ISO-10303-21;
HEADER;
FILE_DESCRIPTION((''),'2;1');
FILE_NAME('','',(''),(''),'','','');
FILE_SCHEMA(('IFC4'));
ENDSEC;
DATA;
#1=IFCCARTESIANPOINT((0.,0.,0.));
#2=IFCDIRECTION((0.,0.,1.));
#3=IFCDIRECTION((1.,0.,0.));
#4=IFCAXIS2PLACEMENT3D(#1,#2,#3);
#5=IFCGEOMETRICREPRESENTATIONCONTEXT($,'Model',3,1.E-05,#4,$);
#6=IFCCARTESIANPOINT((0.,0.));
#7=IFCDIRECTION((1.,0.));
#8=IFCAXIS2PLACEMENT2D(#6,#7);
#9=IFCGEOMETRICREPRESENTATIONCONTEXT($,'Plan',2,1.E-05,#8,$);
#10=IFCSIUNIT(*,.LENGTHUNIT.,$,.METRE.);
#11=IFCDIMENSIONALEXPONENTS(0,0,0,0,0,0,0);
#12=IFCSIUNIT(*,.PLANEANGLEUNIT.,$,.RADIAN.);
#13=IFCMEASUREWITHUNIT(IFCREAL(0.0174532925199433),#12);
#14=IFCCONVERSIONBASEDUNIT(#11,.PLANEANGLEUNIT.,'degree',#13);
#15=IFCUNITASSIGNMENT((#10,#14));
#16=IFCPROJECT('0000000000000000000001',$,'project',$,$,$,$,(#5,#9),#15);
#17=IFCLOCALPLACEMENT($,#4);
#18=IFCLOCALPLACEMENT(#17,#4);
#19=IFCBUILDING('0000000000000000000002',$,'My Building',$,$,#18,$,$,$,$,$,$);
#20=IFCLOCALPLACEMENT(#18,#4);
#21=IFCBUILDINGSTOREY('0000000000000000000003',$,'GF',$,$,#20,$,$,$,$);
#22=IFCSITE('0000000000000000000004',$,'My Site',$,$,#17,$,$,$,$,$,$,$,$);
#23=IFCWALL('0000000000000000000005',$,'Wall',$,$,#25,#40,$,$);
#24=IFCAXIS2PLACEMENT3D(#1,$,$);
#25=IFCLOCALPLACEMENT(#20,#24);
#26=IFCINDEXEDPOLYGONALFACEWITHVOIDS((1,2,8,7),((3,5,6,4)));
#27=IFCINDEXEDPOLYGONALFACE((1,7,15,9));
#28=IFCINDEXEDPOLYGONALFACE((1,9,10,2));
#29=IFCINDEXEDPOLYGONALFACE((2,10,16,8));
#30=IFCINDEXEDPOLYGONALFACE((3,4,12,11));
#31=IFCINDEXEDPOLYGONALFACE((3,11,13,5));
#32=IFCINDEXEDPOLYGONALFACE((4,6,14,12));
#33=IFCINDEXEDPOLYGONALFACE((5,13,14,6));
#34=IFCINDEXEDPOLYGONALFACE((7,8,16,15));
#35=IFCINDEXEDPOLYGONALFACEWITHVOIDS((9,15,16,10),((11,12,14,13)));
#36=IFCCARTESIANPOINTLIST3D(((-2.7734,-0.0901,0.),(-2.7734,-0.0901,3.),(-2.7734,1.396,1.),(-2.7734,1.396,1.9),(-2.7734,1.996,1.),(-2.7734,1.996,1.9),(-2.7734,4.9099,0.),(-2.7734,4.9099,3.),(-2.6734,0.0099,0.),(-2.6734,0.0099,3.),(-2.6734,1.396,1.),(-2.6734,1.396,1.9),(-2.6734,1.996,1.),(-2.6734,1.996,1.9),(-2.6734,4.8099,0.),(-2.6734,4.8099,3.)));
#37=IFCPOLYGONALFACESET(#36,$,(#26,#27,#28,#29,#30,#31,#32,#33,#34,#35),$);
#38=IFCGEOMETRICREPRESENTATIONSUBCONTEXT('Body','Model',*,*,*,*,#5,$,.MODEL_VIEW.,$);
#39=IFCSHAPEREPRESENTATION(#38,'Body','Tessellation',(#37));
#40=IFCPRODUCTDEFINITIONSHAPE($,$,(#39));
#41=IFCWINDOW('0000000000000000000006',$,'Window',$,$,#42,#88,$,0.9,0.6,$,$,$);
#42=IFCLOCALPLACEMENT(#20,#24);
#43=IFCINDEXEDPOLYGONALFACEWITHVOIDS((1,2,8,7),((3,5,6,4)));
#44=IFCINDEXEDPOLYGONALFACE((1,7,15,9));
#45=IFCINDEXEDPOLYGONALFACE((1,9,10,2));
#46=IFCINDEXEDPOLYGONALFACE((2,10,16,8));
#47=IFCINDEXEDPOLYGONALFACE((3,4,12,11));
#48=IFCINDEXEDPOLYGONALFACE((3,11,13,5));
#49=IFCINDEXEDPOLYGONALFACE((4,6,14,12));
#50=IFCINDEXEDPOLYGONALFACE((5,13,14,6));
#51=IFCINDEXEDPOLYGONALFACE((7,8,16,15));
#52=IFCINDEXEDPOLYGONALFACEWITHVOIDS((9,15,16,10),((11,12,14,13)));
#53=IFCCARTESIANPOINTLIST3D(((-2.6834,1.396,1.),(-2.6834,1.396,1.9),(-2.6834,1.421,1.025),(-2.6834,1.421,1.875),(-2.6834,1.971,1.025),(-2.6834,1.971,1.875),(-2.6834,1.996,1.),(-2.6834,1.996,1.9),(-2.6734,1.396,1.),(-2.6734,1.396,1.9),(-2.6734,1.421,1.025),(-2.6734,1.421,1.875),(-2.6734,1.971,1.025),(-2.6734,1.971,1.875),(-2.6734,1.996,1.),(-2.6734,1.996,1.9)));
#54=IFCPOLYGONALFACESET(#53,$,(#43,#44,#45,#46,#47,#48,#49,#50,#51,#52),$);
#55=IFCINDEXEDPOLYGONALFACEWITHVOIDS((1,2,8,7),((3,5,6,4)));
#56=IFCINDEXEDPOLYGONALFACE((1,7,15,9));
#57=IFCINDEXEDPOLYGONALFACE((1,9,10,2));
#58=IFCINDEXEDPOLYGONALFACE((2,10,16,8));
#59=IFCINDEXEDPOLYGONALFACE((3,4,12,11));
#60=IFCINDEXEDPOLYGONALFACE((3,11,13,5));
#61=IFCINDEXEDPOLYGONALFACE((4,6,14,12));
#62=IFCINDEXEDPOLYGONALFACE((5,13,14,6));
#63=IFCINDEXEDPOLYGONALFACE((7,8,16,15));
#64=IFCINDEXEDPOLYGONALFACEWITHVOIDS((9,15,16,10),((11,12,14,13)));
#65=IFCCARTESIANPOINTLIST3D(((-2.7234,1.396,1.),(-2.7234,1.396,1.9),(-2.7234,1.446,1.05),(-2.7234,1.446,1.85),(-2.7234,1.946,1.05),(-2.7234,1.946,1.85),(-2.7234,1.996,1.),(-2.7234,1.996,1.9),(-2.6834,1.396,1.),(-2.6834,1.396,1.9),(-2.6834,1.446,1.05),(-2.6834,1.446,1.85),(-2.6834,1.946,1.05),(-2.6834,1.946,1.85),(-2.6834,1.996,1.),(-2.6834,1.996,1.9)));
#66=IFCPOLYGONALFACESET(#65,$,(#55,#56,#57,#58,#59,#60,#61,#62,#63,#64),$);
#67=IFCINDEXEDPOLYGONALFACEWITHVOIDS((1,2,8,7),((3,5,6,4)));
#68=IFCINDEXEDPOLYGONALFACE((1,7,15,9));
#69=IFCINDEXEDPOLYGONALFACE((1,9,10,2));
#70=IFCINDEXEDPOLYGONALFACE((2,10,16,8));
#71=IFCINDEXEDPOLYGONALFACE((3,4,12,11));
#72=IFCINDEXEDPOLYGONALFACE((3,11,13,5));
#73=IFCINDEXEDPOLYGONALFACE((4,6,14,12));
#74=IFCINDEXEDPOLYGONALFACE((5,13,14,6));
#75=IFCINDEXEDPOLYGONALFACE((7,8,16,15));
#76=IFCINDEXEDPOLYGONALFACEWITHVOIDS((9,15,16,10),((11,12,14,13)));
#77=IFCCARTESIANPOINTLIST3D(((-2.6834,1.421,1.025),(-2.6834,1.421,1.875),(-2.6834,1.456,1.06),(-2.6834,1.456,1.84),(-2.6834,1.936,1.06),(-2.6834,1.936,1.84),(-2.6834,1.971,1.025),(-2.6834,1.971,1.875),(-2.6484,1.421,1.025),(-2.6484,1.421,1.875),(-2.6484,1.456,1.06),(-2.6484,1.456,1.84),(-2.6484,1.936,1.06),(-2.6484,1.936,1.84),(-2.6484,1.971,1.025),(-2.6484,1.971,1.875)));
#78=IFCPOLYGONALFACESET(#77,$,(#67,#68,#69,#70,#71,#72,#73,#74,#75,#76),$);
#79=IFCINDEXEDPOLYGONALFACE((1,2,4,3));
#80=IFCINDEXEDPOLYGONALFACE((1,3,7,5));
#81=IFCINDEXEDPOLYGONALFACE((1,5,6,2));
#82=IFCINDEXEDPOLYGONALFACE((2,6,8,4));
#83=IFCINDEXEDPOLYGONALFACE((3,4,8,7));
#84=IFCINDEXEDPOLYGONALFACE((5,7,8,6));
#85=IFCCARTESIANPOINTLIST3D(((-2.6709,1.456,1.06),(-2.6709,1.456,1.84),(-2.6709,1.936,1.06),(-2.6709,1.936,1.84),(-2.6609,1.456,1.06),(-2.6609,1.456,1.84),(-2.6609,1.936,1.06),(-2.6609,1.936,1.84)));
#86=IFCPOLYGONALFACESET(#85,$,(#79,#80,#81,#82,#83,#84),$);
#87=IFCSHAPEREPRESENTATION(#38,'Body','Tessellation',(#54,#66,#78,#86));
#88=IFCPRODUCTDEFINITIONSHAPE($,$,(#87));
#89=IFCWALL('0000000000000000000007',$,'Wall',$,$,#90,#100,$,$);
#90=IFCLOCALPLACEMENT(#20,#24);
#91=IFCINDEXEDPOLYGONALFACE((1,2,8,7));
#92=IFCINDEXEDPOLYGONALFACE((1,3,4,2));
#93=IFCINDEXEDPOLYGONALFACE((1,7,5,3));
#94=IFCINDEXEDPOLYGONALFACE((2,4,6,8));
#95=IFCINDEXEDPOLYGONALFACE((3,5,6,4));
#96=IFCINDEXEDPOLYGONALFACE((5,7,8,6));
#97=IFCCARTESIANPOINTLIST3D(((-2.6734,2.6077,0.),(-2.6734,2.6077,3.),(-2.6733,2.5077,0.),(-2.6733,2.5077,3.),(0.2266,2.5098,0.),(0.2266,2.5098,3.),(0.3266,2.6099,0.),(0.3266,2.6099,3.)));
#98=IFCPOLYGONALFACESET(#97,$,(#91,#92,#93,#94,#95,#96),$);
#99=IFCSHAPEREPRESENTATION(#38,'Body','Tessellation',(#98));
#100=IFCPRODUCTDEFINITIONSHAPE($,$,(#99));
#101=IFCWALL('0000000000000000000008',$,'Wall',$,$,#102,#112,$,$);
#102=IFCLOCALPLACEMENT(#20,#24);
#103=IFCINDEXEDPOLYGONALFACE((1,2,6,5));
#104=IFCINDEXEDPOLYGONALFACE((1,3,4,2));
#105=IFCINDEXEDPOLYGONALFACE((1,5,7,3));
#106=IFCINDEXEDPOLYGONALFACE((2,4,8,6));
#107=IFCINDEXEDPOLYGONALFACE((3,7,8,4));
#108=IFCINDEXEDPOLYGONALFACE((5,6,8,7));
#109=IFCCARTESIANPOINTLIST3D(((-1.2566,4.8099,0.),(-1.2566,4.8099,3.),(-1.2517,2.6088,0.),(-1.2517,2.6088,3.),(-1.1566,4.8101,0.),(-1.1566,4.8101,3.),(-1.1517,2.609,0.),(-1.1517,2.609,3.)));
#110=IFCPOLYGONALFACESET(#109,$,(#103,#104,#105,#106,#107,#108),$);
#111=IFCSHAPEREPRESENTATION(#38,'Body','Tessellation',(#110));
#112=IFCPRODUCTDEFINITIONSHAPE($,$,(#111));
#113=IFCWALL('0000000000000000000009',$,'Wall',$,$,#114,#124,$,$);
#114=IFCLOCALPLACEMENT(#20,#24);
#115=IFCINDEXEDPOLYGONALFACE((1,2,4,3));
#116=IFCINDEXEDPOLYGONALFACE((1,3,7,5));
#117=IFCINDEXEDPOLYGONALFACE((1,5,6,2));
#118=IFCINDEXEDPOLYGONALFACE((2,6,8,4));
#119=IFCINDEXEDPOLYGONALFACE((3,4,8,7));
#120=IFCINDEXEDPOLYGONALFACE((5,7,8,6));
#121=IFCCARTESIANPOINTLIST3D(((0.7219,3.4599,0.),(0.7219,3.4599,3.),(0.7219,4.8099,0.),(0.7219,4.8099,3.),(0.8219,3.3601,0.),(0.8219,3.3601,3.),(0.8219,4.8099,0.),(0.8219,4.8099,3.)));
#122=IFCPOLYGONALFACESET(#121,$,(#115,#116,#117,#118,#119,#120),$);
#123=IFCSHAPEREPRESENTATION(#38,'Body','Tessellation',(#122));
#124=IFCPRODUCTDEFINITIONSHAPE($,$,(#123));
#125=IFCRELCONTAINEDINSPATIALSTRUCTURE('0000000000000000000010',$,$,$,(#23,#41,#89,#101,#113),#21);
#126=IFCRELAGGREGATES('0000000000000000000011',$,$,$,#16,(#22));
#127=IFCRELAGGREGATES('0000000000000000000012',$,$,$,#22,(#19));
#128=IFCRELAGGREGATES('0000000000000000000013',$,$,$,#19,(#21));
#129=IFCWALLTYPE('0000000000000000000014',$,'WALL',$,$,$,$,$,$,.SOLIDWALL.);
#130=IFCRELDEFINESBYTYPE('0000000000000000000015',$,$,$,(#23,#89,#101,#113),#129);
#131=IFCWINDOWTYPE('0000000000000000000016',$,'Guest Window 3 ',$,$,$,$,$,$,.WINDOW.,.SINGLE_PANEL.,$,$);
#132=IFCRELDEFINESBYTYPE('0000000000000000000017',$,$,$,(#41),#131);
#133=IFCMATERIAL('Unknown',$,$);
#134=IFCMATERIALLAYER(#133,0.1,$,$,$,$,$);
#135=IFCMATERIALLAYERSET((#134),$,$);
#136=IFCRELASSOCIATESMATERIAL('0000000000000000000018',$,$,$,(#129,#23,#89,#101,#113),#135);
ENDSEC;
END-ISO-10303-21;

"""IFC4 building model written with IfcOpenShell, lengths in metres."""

from ifc_helpers import new_model, entity, si_unit, converted_unit, frame, origin_with_axes, origin_2d_with_axis, place, context, subcontext, project, spatial, line, indexed_curve, outline, extrude, shape, source, transform, mapped, material, layer, layer_set, layer_usage, type_object, type_shapes, element, fill, save


model = new_model("IFC4")

# Units and contexts
model_context = context("Model", 3, precision=1e-05, world=origin_with_axes())
plan_context = context("Plan", 2, precision=1e-05, world=origin_2d_with_axis())
body_context_1 = subcontext(model_context, "Body", "Model", "MODEL_VIEW")
body_context_2 = subcontext(plan_context, "Body", "Plan", "PLAN_VIEW")
ifc_project = project(units=[si_unit("LENGTHUNIT", "METRE"), converted_unit("PLANEANGLEUNIT", "degree", entity("IfcReal", 0.0174532925199433), si_unit("PLANEANGLEUNIT", "RADIAN"), dimensions=[0, 0, 0, 0, 0, 0, 0])], contexts=[model_context, plan_context])

# Site, building, storey
site_placement = place(None, origin_with_axes())
site = spatial("IfcSite", under=ifc_project, at=site_placement, Name="My Site")
building_placement = place(site_placement, origin_with_axes())
building = spatial("IfcBuilding", under=site, at=building_placement, Name="My Building")
storey_placement = place(building_placement, origin_with_axes())
storey = spatial("IfcBuildingStorey", under=building, at=storey_placement, Name="GF")

# Shared definitions
ifc_material = material(Name="Unknown")

# Shared definitions
ifc_layer_1 = layer(ifc_material, 0.1)
ifc_layer_set_1 = layer_set([ifc_layer_1])
wall_type = type_object("IfcWallType", Name="WALL", PredefinedType="SOLIDWALL", material=ifc_layer_set_1)

# Wall, opening, window
ifc_layer_usage_1 = layer_usage(ifc_layer_set_1, "AXIS2", "POSITIVE", 0.0)
wall_1_placement = place(storey_placement, frame((-2.7734, 4.9099, 0.0), z_axis=(0.0, 0.0, 1.0), x_axis=(0.0, -1.0, 0.0)))
wall_1 = element("IfcWall", 1, at=wall_1_placement, inside=storey, type_object=wall_type, material=ifc_layer_usage_1, Name="Wall", context=body_context_1, shape_type="SweptSolid", body=[
    extrude(outline(indexed_curve([(0.0, 0.0), (0.1, 0.1), (4.9, 0.1), (5.0, 0.0)], segments=[line(1, 2, 3, 4, 1)])), origin_with_axes(), (0.0, 0.0, 1.0), 3.0),
])
shared_shape_1 = source(origin_with_axes(), body_context_1, "Body", "SweptSolid", [
    extrude(outline(indexed_curve([(0.0, 0.0), (0.6, 0.0), (0.6, 0.9), (0.0, 0.9)], segments=[line(1, 2, 3, 4, 1)])), frame((0.0, -0.6, 0.0), z_axis=(0.0, -1.0, 0.0), x_axis=(1.0, 0.0, 0.0)), (0.0, 0.0, -1.0), 1.2),
])
opening_1_placement = place(wall_1_placement, frame((2.9139, 0.0, 1.0), z_axis=(0.0, 0.0, 1.0), x_axis=(1.0, 0.0, 0.0)))
opening_1 = element("IfcOpeningElement", 2, at=opening_1_placement, cuts=wall_1, PredefinedType="OPENING", context=body_context_1, shape_type="MappedRepresentation", body=[
    mapped(shared_shape_1, transform((0.0, 0.0, 0.0), x_axis=(1.0, 0.0, 0.0), y_axis=(0.0, 1.0, 0.0), z_axis=(0.0, 0.0, 1.0), scale=1.0)),
])
window_type_1 = type_object("IfcWindowType", Name="Guest Window 3 ", PartitioningType="SINGLE_PANEL", PredefinedType="WINDOW")
shared_shape_2 = source(origin_with_axes(), body_context_1, "Body", "SweptSolid", [
    extrude(outline(indexed_curve([(0.0, 0.0), (0.6, 0.0), (0.6, 0.9), (0.0, 0.9)], segments=[line(1, 2, 3, 4, 1)]), holes=[indexed_curve([(0.025, 0.025), (0.575, 0.025), (0.575, 0.875), (0.025, 0.875)], segments=[line(1, 2, 3, 4, 1)])]), frame((0.0, 0.09, 0.0), z_axis=(0.0, -1.0, 0.0), x_axis=(1.0, 0.0, 0.0)), (0.0, 0.0, -1.0), 0.01),
    extrude(outline(indexed_curve([(0.0, 0.0), (0.6, 0.0), (0.6, 0.9), (0.0, 0.9)], segments=[line(1, 2, 3, 4, 1)]), holes=[indexed_curve([(0.05, 0.05), (0.55, 0.05), (0.55, 0.85), (0.05, 0.85)], segments=[line(1, 2, 3, 4, 1)])]), frame((0.0, 0.05, 0.0), z_axis=(0.0, -1.0, 0.0), x_axis=(1.0, 0.0, 0.0)), (0.0, 0.0, -1.0), 0.04),
    extrude(outline(indexed_curve([(0.0, 0.0), (0.55, 0.0), (0.55, 0.85), (0.0, 0.85)], segments=[line(1, 2, 3, 4, 1)]), holes=[indexed_curve([(0.035, 0.035), (0.515, 0.035), (0.515, 0.815), (0.035, 0.815)], segments=[line(1, 2, 3, 4, 1)])]), frame((0.025, 0.09, 0.025), z_axis=(0.0, -1.0, 0.0), x_axis=(1.0, 0.0, 0.0)), (0.0, 0.0, -1.0), 0.035),
    extrude(outline(indexed_curve([(0.035, 0.035), (0.515, 0.035), (0.515, 0.815), (0.035, 0.815)], segments=[line(1, 2, 3, 4, 1)])), frame((0.025, 0.1025, 0.025), z_axis=(0.0, -1.0, 0.0), x_axis=(1.0, 0.0, 0.0)), (0.0, 0.0, -1.0), 0.01),
])
shared_shape_3 = source(origin_with_axes(), body_context_2, "Body", "Curve2D", [
    entity("IfcIndexedPolyCurve", entity("IfcCartesianPointList2D", [[0.05, 0.05], [0.55, 0.05]])),
    entity("IfcIndexedPolyCurve", entity("IfcCartesianPointList2D", [[0.0, 0.1], [0.025, 0.1], [0.025, 0.09], [0.05, 0.09], [0.05, 0.05], [0.0, 0.05]]), [entity("IfcLineIndex", [1, 2, 3, 4, 5, 6, 1])]),
    entity("IfcIndexedPolyCurve", entity("IfcCartesianPointList2D", [[0.6, 0.1], [0.575, 0.1], [0.575, 0.09], [0.55, 0.09], [0.55, 0.05], [0.6, 0.05]]), [entity("IfcLineIndex", [1, 2, 3, 4, 5, 6, 1])]),
    entity("IfcIndexedPolyCurve", entity("IfcCartesianPointList2D", [[0.025, 0.09], [0.06, 0.09], [0.06, 0.125], [0.025, 0.125]]), [entity("IfcLineIndex", [1, 2, 3, 4, 1])]),
    entity("IfcIndexedPolyCurve", entity("IfcCartesianPointList2D", [[0.575, 0.09], [0.54, 0.09], [0.54, 0.125], [0.575, 0.125]]), [entity("IfcLineIndex", [1, 2, 3, 4, 1])]),
    entity("IfcIndexedPolyCurve", entity("IfcCartesianPointList2D", [[0.06, 0.09], [0.54, 0.09]])),
    entity("IfcIndexedPolyCurve", entity("IfcCartesianPointList2D", [[0.06, 0.125], [0.54, 0.125]])),
    entity("IfcIndexedPolyCurve", entity("IfcCartesianPointList2D", [[0.06, 0.1075], [0.54, 0.1075]])),
])
type_shapes(window_type_1, [shared_shape_2, shared_shape_3])
window_1_placement = place(opening_1_placement, origin_with_axes())
window_1 = element("IfcWindow", 3, at=window_1_placement, inside=storey, type_object=window_type_1, Name="Window", OverallHeight=0.9, OverallWidth=0.6, shapes=[
    shape(body_context_1, "Body", "MappedRepresentation", [mapped(shared_shape_2, transform((0.0, 0.0, 0.0), x_axis=(1.0, 0.0, 0.0), y_axis=(0.0, 1.0, 0.0), z_axis=(0.0, 0.0, 1.0), scale=1.0))]),
    shape(body_context_2, "Body", "MappedRepresentation", [mapped(shared_shape_3, transform((0.0, 0.0, 0.0), x_axis=(1.0, 0.0, 0.0), y_axis=(0.0, 1.0, 0.0), z_axis=(0.0, 0.0, 1.0), scale=1.0))]),
])
fill(opening_1, window_1)

# Walls
ifc_layer_usage_2 = layer_usage(ifc_layer_set_1, "AXIS2", "POSITIVE", 0.0)
wall_2_placement = place(storey_placement, frame((0.3266, 2.6099, 0.0), z_axis=(0.0, 0.0, 1.0), x_axis=(-1.0, -0.000723, 0.0)))
element("IfcWall", 4, at=wall_2_placement, inside=storey, type_object=wall_type, material=ifc_layer_usage_2, Name="Wall", context=body_context_1, shape_type="SweptSolid", body=[
    extrude(outline(indexed_curve([(0.0, 0.0), (0.1001, 0.1), (3.0, 0.1), (3.0, 0.0)], segments=[line(1, 2, 3, 4, 1)])), origin_with_axes(), (0.0, 0.0, 1.0), 3.0),
])
ifc_layer_usage_3 = layer_usage(ifc_layer_set_1, "AXIS2", "POSITIVE", 0.0)
wall_3_placement = place(storey_placement, frame((-1.2566, 4.8099, 0.0), z_axis=(0.0, 0.0, 1.0), x_axis=(0.002212, -0.999998, 0.0)))
element("IfcWall", 5, at=wall_3_placement, inside=storey, type_object=wall_type, material=ifc_layer_usage_3, Name="Wall", context=body_context_1, shape_type="SweptSolid", body=[
    extrude(outline(indexed_curve([(0.0, 0.0), (0.0, 0.1), (2.2011, 0.1), (2.2011, 0.0)], segments=[line(1, 2, 3, 4, 1)])), origin_with_axes(), (0.0, 0.0, 1.0), 3.0),
])
ifc_layer_usage_4 = layer_usage(ifc_layer_set_1, "AXIS2", "POSITIVE", 0.0)
wall_4_placement = place(storey_placement, frame((0.7219, 4.8099, 0.0), z_axis=(0.0, 0.0, 1.0), x_axis=(0.0, -1.0, 0.0)))
element("IfcWall", 6, at=wall_4_placement, inside=storey, type_object=wall_type, material=ifc_layer_usage_4, Name="Wall", context=body_context_1, shape_type="SweptSolid", body=[
    extrude(outline(indexed_curve([(0.0, 0.0), (0.0, 0.1), (1.4498, 0.1), (1.35, 0.0)], segments=[line(1, 2, 3, 4, 1)])), origin_with_axes(), (0.0, 0.0, 1.0), 3.0),
])

save(model, "model.ifc")
